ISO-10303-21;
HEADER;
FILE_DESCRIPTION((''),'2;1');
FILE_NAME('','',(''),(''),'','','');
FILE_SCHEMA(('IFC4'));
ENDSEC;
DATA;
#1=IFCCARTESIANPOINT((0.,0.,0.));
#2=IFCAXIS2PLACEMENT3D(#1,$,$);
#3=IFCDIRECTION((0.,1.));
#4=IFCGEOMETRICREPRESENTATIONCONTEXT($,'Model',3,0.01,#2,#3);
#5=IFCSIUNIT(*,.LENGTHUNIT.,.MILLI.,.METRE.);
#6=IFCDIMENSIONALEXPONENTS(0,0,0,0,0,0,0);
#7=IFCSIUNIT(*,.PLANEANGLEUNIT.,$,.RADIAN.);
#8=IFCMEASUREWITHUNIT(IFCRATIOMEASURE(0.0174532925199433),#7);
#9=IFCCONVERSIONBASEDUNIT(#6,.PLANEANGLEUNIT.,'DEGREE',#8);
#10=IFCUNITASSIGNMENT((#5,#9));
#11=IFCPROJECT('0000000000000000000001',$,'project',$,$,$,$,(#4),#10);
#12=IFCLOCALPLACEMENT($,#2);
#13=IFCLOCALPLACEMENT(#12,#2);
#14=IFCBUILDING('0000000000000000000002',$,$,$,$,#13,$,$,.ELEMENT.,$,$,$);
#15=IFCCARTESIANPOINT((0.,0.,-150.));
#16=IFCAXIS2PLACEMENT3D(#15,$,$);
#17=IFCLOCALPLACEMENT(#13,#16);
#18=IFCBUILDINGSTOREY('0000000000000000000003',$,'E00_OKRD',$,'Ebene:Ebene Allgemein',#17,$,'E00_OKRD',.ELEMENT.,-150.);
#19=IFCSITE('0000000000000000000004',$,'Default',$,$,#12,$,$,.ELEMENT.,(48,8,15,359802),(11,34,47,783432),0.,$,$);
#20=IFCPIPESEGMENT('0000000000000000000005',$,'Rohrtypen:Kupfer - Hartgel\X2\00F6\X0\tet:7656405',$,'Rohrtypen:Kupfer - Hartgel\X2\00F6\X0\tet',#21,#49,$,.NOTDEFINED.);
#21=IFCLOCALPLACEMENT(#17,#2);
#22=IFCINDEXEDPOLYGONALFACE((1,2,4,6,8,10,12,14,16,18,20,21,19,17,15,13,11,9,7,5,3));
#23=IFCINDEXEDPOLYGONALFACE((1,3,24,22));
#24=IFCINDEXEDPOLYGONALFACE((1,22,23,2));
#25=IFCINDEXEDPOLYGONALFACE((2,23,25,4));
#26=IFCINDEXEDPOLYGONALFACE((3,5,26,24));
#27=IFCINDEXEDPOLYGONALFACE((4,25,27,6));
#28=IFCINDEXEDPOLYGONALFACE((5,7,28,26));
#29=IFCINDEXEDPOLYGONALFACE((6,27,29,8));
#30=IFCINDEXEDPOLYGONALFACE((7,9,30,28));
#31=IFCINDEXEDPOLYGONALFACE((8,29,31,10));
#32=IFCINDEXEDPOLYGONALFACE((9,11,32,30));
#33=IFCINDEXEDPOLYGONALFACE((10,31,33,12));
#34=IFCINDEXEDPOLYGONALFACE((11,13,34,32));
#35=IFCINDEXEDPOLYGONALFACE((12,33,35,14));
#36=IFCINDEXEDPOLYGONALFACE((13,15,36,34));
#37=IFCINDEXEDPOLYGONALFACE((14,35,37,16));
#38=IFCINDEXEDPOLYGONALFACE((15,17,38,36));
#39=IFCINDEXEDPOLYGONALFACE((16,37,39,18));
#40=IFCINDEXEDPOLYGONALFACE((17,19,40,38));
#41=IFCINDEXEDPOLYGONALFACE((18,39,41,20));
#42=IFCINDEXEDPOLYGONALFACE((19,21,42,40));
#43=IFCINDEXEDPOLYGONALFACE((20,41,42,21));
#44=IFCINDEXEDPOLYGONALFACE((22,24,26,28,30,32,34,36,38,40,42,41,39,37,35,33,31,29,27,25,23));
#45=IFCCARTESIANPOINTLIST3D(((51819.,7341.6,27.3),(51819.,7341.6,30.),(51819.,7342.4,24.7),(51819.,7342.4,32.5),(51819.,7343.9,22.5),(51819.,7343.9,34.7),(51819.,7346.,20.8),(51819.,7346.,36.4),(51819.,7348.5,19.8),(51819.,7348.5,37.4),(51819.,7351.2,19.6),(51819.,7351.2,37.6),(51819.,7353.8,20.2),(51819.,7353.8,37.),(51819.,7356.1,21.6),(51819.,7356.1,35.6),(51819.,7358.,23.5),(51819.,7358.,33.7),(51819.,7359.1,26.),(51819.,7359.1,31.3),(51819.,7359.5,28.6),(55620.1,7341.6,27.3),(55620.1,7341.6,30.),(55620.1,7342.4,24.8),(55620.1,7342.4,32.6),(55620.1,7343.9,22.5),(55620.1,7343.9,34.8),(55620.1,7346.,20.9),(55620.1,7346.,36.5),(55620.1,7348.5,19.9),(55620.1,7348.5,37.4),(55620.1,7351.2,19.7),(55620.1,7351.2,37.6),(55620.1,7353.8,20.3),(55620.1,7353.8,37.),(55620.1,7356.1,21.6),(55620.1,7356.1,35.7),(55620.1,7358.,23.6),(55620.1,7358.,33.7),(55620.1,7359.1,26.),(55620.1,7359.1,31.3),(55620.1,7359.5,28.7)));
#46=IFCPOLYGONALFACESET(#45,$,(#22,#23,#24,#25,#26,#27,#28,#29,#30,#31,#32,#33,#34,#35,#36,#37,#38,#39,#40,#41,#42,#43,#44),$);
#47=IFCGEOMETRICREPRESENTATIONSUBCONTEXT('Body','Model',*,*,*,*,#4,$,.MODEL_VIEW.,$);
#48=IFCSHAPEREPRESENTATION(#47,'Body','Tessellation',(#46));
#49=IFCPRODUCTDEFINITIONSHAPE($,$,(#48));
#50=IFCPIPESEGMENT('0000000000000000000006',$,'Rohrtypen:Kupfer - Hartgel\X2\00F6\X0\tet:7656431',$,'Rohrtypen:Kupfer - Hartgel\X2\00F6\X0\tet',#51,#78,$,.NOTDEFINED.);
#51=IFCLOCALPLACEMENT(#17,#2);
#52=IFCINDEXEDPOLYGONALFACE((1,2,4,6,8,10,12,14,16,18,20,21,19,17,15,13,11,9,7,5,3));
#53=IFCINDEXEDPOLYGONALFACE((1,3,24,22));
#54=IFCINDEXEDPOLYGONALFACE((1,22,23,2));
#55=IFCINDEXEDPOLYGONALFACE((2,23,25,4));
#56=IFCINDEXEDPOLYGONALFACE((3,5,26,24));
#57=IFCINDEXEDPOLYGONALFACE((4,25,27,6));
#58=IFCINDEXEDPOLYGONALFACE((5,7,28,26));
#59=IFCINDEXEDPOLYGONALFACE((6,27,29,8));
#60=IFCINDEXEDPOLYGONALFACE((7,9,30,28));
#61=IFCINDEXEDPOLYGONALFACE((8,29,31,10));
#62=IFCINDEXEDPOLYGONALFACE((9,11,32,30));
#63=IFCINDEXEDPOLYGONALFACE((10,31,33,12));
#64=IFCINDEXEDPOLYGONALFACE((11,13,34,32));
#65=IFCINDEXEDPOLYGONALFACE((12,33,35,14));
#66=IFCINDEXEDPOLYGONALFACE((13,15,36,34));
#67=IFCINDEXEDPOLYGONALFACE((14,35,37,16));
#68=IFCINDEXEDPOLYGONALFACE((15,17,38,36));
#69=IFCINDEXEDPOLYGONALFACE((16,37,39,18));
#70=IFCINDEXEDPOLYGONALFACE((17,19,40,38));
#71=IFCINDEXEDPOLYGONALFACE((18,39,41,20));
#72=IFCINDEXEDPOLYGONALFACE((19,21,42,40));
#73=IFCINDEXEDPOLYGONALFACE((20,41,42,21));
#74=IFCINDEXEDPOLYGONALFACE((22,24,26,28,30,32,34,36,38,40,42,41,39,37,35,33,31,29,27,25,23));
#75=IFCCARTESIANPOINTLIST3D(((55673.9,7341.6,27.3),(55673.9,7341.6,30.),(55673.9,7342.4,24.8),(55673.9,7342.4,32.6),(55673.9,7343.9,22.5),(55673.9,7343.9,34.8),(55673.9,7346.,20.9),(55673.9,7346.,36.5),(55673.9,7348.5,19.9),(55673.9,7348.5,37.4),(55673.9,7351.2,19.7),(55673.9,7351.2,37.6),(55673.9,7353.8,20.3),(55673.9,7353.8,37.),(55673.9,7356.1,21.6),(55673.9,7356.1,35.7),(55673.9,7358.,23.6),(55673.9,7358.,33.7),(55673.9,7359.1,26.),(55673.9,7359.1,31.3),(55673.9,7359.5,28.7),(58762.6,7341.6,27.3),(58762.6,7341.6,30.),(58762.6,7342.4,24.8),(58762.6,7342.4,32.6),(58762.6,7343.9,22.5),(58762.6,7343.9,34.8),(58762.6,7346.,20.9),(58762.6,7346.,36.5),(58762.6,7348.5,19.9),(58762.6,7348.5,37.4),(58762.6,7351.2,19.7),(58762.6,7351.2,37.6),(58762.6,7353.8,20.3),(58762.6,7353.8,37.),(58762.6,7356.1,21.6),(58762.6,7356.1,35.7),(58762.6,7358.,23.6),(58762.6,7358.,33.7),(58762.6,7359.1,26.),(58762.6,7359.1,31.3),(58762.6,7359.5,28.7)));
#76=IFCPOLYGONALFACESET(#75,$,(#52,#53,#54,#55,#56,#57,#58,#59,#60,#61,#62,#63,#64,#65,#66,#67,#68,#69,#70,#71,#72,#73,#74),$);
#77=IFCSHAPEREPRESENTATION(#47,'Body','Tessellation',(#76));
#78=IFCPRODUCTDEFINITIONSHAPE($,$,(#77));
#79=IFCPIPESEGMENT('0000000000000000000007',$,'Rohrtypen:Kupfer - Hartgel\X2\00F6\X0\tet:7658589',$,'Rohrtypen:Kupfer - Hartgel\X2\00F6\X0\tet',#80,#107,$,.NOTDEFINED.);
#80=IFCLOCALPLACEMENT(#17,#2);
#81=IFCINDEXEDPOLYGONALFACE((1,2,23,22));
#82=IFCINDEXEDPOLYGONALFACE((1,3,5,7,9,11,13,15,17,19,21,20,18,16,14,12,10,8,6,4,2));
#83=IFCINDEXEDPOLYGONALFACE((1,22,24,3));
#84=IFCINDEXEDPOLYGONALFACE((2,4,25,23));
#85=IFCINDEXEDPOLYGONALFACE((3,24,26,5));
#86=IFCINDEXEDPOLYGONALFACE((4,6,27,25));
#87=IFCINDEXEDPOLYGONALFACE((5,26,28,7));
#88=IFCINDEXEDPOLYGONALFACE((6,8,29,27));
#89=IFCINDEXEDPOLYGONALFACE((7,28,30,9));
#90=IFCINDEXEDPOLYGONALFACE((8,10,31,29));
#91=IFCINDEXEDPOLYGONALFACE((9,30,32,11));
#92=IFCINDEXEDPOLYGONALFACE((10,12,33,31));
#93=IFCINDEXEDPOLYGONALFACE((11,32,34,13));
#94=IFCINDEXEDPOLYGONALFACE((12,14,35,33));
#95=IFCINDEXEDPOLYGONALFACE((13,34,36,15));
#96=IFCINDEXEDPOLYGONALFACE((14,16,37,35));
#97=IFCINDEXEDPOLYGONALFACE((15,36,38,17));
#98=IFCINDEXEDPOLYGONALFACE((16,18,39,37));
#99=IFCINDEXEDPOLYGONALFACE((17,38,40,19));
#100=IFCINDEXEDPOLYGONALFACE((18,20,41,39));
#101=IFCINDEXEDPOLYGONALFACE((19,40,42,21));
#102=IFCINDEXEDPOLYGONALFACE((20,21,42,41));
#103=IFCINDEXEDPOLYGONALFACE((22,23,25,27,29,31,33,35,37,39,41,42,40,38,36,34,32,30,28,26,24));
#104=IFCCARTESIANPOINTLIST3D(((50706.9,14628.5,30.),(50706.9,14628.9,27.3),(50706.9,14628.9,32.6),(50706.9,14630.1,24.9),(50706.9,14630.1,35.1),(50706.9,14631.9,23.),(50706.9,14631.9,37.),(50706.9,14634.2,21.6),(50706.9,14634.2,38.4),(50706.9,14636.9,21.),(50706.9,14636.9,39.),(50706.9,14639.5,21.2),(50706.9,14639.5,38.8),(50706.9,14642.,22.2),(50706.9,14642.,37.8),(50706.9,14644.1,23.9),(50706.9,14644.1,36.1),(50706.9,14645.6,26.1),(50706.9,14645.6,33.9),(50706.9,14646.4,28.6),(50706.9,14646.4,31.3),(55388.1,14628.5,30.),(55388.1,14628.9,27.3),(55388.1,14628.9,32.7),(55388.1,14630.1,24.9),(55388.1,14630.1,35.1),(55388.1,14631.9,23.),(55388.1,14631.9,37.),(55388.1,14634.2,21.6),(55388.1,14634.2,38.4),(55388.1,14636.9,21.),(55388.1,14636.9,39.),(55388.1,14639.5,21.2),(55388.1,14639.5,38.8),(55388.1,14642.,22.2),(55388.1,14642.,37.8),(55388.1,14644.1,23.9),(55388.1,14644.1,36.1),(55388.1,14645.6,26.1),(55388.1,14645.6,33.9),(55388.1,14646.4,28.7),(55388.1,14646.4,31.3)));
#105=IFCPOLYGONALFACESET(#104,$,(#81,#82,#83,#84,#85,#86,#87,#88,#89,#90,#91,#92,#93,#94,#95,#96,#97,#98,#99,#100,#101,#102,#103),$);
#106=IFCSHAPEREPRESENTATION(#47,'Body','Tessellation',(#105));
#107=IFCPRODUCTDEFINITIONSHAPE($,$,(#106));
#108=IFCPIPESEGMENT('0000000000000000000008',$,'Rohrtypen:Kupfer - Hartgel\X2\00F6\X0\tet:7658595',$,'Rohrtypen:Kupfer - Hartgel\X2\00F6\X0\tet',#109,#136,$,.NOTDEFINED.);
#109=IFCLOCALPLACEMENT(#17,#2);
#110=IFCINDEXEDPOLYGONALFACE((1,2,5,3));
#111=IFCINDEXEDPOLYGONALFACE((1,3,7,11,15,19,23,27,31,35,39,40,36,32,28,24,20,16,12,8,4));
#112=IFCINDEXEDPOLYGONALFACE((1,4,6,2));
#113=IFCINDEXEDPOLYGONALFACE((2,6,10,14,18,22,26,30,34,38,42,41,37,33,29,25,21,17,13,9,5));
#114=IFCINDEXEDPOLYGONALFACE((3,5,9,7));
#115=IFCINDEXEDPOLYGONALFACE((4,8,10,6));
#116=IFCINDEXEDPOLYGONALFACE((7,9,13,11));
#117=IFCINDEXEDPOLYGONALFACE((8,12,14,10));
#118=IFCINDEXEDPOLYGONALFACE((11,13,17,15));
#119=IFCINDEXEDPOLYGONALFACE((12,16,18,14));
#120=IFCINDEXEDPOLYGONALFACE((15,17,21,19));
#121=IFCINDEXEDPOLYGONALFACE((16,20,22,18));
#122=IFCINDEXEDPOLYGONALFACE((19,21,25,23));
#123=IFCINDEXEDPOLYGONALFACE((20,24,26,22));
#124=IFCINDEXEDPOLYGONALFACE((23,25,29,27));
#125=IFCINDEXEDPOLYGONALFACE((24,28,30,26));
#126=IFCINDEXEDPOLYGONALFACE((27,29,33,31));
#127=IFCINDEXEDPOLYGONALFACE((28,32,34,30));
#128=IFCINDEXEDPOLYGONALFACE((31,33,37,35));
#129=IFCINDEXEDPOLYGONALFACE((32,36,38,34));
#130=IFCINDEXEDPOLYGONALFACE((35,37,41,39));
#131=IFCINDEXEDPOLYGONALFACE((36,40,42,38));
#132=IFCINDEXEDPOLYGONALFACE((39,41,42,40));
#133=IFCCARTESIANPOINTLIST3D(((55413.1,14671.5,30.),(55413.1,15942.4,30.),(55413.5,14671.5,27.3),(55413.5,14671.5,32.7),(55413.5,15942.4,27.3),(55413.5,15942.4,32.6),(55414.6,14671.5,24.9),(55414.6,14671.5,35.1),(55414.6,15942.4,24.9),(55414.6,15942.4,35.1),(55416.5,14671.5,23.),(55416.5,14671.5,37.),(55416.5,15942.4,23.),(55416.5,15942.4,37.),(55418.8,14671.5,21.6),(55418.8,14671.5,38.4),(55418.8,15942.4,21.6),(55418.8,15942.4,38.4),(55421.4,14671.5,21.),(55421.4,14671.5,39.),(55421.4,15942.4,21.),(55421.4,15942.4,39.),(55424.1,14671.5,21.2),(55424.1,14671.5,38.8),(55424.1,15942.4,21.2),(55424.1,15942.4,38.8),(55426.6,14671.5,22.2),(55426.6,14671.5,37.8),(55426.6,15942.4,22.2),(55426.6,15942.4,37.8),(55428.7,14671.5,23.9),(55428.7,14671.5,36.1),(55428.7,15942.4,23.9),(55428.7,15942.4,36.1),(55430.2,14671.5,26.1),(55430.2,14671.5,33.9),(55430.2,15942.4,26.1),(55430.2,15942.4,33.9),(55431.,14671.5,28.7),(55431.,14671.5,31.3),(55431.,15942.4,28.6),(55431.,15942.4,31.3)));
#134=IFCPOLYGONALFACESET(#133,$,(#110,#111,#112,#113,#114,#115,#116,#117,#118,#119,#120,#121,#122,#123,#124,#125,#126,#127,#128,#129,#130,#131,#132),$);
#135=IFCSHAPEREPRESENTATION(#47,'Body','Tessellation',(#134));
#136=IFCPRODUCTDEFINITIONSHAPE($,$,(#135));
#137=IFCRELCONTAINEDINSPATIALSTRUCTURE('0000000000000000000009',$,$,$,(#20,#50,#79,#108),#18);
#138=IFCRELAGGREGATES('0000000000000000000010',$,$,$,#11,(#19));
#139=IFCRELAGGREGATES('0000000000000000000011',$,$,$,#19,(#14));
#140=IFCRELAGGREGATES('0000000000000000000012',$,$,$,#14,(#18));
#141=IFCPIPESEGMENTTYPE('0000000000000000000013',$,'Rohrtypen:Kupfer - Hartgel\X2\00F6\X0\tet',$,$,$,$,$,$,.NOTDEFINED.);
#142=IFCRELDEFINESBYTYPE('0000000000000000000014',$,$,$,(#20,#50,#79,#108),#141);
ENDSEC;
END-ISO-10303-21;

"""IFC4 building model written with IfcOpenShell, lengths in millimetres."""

from ifc_helpers import new_model, entity, si_unit, converted_unit, direction, frame, frame_2d, origin, origin_2d_with_axis, place, context, subcontext, project, spatial, circle, extrude, type_object, element, save


model = new_model("IFC4")

# Units and contexts
model_context = context("Model", 3, precision=0.01, world=origin(), true_north=direction((0.0, 1.0)))
body_context = subcontext(model_context, "Body", "Model", "MODEL_VIEW")
ifc_project = project(units=[si_unit("LENGTHUNIT", "METRE", prefix="MILLI"), converted_unit("PLANEANGLEUNIT", "DEGREE", entity("IfcRatioMeasure", 0.0174532925199433), si_unit("PLANEANGLEUNIT", "RADIAN"), dimensions=[0, 0, 0, 0, 0, 0, 0])], contexts=[model_context])

# Site, building, storey
site_placement = place(None, origin())
site = spatial("IfcSite", under=ifc_project, at=site_placement, Name="Default", CompositionType="ELEMENT", RefLatitude=(48, 8, 15, 359802), RefLongitude=(11, 34, 47, 783432), RefElevation=0.0)
building_placement = place(site_placement, origin())
building = spatial("IfcBuilding", under=site, at=building_placement, CompositionType="ELEMENT")
storey_placement = place(building_placement, frame((0.0, 0.0, -150.0)))
storey = spatial("IfcBuildingStorey", under=building, at=storey_placement, Name="E00_OKRD", ObjectType="Ebene:Ebene Allgemein", LongName="E00_OKRD", CompositionType="ELEMENT", Elevation=-150.0)

# Pipe segments
pipe_segment_type = type_object("IfcPipeSegmentType", Name="Rohrtypen:Kupfer - Hartgelötet", PredefinedType="NOTDEFINED")
pipe_segment_1_placement = place(storey_placement, frame((51819.0, 7339.9, 18.0)))
element("IfcPipeSegment", 1, at=pipe_segment_1_placement, inside=storey, type_object=pipe_segment_type, Name="Rohrtypen:Kupfer - Hartgelötet:7656405", ObjectType="Rohrtypen:Kupfer - Hartgelötet", PredefinedType="NOTDEFINED", context=body_context, shape_type="SweptSolid", body=[
    extrude(circle(Radius=9.0, at=frame_2d((0.0, 0.0), x_axis=(1.0, 0.0))), frame((0.0, 10.6, 10.6), z_axis=(1.0, 0.0, 0.000013), x_axis=(0.0, 1.0, 0.0)), (0.0, 0.0, 1.0), 3801.1),
])
pipe_segment_2_placement = place(storey_placement, frame((55673.9, 7339.9, 18.1)))
element("IfcPipeSegment", 2, at=pipe_segment_2_placement, inside=storey, type_object=pipe_segment_type, Name="Rohrtypen:Kupfer - Hartgelötet:7656431", ObjectType="Rohrtypen:Kupfer - Hartgelötet", PredefinedType="NOTDEFINED", context=body_context, shape_type="SweptSolid", body=[
    extrude(circle(Radius=9.0, at=frame_2d((0.0, 0.0), x_axis=(1.0, 0.0))), frame((0.0, 10.6, 10.6), z_axis=(1.0, 0.0, 0.0), x_axis=(0.0, 1.0, 0.0)), (0.0, 0.0, 1.0), 3088.8),
])
pipe_segment_3_placement = place(storey_placement, frame((50706.9, 14626.9, 19.4)))
element("IfcPipeSegment", 3, at=pipe_segment_3_placement, inside=storey, type_object=pipe_segment_type, Name="Rohrtypen:Kupfer - Hartgelötet:7658589", ObjectType="Rohrtypen:Kupfer - Hartgelötet", PredefinedType="NOTDEFINED", context=body_context, shape_type="SweptSolid", body=[
    extrude(circle(Radius=9.0, at=frame_2d((0.0, 0.0), x_axis=(1.0, 0.0))), frame((0.0, 10.6, 10.6), z_axis=(1.0, 0.0, 0.000002), x_axis=(0.0, -1.0, 0.0)), (0.0, 0.0, 1.0), 4681.2),
])
pipe_segment_4_placement = place(storey_placement, frame((55411.5, 14671.5, 19.4)))
element("IfcPipeSegment", 4, at=pipe_segment_4_placement, inside=storey, type_object=pipe_segment_type, Name="Rohrtypen:Kupfer - Hartgelötet:7658595", ObjectType="Rohrtypen:Kupfer - Hartgelötet", PredefinedType="NOTDEFINED", context=body_context, shape_type="SweptSolid", body=[
    extrude(circle(Radius=9.0, at=origin_2d_with_axis()), frame((10.6, 0.0, 10.6), z_axis=(0.0, 1.0, -0.000009), x_axis=(-1.0, 0.0, 0.0)), (0.0, 0.0, 1.0), 1270.9),
])

save(model, "model.ifc")
